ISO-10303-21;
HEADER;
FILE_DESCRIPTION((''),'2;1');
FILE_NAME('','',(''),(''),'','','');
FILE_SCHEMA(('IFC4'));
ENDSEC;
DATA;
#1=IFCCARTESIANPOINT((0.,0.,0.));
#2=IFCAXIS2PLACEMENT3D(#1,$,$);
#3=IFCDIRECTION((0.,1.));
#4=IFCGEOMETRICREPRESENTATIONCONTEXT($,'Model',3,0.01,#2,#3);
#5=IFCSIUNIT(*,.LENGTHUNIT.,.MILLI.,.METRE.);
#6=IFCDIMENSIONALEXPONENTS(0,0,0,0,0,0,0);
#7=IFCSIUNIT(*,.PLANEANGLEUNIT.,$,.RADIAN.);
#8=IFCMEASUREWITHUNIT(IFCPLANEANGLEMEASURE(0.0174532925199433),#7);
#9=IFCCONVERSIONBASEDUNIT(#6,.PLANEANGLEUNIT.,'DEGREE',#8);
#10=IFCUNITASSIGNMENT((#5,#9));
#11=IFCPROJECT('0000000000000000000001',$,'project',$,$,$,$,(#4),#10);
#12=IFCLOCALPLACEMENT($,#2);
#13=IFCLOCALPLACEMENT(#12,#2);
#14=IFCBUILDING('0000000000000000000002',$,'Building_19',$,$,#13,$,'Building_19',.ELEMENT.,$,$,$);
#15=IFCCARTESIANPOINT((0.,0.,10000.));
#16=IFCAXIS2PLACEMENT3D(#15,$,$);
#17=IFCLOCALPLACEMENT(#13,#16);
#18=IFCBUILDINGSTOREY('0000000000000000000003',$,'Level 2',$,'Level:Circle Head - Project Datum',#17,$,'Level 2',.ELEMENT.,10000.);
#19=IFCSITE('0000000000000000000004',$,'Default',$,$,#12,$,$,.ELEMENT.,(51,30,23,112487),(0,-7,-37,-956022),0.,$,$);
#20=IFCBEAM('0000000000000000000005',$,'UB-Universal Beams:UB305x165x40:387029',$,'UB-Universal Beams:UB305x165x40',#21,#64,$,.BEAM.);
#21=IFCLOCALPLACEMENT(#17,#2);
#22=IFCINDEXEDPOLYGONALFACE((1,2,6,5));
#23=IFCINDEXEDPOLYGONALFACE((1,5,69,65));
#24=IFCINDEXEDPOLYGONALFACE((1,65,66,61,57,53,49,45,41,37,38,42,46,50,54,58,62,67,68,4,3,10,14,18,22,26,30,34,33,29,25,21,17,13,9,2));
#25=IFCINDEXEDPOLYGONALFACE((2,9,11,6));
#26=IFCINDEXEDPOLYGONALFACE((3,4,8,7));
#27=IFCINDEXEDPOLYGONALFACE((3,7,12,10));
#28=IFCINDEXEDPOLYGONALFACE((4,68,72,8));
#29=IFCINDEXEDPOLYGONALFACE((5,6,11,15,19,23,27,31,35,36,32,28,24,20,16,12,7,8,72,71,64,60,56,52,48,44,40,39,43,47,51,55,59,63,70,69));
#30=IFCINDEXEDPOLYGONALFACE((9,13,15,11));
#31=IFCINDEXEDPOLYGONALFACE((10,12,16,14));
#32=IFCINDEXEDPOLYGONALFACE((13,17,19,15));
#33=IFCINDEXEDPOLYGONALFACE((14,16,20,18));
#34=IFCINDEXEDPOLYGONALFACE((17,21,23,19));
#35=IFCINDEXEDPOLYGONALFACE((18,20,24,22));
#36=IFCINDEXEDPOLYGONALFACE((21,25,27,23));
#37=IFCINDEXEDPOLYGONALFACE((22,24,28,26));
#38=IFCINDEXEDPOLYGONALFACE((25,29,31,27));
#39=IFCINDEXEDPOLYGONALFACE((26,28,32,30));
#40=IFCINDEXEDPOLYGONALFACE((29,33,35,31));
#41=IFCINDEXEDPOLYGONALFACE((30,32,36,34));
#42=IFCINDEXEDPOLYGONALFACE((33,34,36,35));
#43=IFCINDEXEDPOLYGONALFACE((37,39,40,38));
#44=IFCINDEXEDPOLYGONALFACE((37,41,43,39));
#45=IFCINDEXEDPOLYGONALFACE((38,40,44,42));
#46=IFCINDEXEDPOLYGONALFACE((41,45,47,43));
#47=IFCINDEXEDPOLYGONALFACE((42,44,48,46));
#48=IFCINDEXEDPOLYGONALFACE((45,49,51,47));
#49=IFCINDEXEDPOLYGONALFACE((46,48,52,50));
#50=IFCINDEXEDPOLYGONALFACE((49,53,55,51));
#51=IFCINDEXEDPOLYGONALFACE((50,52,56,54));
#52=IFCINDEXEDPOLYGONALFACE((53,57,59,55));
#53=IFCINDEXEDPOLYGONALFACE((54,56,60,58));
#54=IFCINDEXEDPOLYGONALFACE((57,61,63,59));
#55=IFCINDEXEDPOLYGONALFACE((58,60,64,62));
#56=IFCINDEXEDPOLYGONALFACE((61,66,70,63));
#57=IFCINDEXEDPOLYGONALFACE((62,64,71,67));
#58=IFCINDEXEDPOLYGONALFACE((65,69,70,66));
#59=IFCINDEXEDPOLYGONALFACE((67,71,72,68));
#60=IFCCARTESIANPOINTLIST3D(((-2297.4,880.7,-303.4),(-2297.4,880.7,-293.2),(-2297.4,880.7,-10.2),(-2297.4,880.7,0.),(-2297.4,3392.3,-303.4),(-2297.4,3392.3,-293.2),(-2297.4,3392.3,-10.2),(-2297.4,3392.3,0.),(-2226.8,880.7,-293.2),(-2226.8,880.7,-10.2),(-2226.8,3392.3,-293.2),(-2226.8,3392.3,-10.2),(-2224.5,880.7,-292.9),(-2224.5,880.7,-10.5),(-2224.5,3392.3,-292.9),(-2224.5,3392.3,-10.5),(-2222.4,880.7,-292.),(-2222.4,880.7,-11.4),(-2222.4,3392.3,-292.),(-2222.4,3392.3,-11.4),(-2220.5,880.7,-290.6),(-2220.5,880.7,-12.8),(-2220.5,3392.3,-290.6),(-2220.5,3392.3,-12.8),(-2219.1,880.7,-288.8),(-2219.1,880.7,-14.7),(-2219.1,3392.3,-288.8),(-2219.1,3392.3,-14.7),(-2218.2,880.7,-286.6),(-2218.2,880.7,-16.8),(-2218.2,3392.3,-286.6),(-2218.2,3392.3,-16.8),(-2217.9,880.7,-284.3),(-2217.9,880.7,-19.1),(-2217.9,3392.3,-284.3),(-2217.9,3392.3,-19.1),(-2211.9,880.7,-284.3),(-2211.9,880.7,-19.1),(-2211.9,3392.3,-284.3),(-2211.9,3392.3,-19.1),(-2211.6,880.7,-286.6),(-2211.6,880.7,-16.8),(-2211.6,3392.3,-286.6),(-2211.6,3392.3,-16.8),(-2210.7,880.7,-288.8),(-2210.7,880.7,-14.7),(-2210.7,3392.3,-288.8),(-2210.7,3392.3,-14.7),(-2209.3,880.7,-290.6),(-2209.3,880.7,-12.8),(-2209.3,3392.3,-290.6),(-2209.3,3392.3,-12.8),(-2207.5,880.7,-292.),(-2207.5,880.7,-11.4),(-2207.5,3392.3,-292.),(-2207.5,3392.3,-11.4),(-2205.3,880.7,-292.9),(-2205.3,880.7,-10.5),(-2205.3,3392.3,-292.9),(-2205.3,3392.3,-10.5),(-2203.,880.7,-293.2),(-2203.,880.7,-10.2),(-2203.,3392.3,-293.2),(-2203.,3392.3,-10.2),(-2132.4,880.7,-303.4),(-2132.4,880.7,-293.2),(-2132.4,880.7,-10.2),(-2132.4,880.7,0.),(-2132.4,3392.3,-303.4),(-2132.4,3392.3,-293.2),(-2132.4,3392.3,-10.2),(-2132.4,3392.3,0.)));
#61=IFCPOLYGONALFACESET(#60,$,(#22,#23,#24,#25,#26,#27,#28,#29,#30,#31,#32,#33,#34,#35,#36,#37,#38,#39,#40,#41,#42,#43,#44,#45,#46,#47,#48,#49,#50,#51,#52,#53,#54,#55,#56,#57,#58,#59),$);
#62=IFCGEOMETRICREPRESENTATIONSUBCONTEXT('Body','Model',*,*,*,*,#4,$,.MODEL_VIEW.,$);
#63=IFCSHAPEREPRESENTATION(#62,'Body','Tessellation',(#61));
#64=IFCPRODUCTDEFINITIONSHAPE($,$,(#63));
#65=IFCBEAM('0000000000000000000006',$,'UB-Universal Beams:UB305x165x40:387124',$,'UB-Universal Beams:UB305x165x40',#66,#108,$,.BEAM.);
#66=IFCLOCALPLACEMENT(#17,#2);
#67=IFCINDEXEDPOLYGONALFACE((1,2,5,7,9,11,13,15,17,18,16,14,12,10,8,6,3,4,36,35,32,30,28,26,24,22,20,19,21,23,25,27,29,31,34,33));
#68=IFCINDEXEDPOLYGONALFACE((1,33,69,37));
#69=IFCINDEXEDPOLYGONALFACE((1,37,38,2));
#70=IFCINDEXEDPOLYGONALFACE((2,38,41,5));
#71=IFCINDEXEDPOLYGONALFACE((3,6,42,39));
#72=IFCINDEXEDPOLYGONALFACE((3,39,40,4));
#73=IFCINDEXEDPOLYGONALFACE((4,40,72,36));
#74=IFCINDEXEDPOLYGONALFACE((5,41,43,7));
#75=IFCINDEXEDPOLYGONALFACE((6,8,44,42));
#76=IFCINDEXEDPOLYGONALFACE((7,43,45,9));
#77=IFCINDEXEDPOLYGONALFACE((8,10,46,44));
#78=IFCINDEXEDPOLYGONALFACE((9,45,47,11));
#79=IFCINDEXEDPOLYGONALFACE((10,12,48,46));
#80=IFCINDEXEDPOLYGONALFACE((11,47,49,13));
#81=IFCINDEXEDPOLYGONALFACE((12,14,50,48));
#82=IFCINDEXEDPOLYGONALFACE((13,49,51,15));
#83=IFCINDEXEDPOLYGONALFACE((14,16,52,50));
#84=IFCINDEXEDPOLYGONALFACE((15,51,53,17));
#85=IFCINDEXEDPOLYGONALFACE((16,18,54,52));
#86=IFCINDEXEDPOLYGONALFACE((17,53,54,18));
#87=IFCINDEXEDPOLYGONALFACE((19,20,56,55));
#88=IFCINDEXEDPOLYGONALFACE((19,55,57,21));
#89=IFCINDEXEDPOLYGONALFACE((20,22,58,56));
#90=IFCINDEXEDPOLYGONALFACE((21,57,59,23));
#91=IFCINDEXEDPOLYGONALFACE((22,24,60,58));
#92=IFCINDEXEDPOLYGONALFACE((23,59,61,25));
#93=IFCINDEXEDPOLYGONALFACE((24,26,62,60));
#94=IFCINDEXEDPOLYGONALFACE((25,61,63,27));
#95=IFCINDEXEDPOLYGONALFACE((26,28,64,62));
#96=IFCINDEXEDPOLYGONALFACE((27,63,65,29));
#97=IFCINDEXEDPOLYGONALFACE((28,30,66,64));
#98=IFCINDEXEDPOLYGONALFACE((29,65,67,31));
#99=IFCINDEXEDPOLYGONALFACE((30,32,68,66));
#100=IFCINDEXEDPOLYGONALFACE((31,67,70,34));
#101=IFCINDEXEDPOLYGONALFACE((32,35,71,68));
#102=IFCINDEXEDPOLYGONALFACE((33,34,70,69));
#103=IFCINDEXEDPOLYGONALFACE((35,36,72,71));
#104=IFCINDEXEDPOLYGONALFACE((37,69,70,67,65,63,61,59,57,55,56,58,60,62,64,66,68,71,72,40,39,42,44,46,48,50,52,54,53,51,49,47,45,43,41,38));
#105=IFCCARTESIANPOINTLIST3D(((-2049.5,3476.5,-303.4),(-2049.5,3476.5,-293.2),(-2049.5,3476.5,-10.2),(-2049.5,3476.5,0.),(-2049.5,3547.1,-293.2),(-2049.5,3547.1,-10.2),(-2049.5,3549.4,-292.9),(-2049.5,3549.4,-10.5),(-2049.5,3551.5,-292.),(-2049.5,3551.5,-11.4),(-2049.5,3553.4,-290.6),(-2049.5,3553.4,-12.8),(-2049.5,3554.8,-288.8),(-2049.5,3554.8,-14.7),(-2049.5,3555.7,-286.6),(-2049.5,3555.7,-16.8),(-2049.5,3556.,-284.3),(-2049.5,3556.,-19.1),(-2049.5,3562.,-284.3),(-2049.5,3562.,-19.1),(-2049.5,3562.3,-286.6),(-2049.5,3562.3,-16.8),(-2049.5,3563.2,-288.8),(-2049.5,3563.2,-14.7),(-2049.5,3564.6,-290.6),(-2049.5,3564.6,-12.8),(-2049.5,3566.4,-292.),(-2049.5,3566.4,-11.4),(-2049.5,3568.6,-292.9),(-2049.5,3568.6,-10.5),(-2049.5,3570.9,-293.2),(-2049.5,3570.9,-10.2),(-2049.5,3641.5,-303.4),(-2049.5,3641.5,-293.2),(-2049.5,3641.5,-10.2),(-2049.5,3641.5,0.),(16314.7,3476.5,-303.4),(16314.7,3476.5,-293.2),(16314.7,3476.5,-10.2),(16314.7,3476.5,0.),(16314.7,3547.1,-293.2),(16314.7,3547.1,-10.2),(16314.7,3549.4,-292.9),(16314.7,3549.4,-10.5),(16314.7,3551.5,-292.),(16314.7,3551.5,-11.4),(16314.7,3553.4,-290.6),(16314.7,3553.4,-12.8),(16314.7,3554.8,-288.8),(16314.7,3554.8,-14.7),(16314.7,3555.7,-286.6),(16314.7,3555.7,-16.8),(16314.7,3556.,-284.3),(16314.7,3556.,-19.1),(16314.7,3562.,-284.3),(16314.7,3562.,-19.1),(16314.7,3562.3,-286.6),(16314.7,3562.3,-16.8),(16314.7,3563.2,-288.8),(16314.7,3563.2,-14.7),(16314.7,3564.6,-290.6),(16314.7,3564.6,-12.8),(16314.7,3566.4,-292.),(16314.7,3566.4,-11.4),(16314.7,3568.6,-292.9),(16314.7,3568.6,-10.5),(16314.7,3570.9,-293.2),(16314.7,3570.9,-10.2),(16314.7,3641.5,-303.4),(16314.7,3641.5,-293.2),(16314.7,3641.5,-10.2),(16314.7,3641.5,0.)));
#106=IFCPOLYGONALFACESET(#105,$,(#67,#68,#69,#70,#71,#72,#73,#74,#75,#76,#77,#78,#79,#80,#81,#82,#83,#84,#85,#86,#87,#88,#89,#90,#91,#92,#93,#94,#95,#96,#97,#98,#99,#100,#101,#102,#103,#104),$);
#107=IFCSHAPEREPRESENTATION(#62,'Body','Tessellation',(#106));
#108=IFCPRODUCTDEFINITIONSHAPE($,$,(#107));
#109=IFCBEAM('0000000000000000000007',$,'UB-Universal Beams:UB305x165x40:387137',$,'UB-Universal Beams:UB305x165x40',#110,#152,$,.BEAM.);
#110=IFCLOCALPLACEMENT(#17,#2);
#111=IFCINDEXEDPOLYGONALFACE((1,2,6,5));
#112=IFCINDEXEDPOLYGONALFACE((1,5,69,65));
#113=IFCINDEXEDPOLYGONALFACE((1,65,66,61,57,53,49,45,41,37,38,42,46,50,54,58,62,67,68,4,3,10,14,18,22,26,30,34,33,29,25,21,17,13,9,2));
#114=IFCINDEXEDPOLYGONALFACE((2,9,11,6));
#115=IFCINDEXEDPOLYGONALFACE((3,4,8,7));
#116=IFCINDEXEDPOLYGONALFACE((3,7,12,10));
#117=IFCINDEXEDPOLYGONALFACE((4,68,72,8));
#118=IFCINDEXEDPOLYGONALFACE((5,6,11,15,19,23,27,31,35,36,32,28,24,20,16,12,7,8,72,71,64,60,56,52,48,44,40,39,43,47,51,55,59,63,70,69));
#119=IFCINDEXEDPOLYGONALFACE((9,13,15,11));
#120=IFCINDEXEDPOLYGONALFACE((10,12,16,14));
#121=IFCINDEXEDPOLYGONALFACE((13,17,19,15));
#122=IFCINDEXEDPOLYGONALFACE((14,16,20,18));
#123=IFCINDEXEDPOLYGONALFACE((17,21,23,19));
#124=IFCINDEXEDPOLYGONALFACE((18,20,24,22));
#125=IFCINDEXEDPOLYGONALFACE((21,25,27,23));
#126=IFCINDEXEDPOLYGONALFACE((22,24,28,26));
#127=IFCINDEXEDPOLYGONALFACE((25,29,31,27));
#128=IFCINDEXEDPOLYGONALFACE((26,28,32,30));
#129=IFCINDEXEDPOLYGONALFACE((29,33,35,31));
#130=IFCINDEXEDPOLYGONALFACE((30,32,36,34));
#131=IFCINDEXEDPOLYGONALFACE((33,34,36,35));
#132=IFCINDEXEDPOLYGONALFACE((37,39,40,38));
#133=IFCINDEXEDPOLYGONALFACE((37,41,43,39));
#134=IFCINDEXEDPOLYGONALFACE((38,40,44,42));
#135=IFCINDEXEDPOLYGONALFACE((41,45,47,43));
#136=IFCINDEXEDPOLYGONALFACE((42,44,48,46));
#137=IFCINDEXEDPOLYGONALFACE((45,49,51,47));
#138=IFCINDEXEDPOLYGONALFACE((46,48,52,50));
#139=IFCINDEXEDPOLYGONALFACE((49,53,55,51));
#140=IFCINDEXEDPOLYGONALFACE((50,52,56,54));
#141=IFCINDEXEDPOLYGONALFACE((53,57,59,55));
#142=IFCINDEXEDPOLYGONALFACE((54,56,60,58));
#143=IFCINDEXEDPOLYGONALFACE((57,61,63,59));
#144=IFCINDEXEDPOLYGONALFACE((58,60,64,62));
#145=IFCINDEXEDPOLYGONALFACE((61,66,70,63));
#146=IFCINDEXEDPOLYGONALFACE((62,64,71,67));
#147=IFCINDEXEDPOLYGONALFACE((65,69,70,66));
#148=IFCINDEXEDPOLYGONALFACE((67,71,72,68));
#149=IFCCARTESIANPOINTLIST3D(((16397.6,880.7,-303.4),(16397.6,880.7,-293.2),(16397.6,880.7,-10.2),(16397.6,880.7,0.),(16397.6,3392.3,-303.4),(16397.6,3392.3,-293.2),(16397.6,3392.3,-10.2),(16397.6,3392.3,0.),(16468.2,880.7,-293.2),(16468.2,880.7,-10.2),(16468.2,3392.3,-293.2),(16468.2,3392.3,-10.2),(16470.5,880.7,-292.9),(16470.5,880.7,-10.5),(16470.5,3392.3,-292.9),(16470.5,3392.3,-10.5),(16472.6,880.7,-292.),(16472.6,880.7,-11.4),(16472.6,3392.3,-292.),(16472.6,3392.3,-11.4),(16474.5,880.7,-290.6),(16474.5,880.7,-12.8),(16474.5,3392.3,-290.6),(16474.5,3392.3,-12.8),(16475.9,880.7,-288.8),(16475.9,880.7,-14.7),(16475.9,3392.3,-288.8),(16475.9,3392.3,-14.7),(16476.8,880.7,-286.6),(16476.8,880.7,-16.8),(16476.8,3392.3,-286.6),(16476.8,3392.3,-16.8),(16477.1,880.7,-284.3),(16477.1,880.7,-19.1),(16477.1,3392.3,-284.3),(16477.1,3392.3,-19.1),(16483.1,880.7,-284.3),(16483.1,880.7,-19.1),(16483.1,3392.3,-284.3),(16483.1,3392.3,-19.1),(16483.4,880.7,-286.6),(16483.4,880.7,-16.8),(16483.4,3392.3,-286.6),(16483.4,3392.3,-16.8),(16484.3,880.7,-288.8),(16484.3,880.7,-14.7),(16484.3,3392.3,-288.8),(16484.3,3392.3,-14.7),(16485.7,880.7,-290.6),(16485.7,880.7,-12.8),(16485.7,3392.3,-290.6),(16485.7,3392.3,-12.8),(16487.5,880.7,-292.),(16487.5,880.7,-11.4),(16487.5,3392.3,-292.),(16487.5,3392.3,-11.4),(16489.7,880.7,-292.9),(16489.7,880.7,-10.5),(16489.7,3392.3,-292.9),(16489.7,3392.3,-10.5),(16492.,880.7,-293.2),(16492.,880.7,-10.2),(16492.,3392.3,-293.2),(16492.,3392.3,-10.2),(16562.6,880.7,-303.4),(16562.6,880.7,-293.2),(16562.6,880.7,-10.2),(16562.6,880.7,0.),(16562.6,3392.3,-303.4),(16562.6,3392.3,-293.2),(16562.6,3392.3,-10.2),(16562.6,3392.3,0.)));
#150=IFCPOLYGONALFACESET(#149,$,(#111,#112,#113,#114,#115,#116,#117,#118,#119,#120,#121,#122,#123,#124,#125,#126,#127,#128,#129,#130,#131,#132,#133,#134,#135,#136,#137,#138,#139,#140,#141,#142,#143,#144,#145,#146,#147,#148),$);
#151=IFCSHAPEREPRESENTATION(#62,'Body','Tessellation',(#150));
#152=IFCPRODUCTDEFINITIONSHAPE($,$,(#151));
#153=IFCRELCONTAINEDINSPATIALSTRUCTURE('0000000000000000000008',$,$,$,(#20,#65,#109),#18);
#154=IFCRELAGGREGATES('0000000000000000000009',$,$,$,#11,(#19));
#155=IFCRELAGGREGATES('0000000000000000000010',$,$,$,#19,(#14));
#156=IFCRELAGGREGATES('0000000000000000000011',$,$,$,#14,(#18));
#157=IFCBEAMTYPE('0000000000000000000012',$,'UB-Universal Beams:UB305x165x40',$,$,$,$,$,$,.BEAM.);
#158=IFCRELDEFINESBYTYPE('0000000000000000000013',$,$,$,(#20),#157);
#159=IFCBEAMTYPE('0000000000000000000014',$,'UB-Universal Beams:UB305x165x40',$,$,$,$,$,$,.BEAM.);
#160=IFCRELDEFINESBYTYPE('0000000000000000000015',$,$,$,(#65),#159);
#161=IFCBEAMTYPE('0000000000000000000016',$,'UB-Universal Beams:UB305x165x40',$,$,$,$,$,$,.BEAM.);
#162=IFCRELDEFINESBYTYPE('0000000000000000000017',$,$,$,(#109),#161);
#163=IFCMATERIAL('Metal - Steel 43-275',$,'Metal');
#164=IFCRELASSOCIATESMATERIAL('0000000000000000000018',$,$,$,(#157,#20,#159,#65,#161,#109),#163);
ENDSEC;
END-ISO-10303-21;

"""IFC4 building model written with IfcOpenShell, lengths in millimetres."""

from ifc_helpers import new_model, entity, si_unit, converted_unit, direction, frame, origin, place, context, subcontext, project, spatial, line, arc, indexed_curve, outline, extrude, source, transform, mapped, material, type_object, type_shapes, element, save


model = new_model("IFC4")

# Units and contexts
model_context = context("Model", 3, precision=0.01, world=origin(), true_north=direction((0.0, 1.0)))
body_context = subcontext(model_context, "Body", "Model", "MODEL_VIEW")
ifc_project = project(units=[si_unit("LENGTHUNIT", "METRE", prefix="MILLI"), converted_unit("PLANEANGLEUNIT", "DEGREE", entity("IfcPlaneAngleMeasure", 0.0174532925199433), si_unit("PLANEANGLEUNIT", "RADIAN"), dimensions=[0, 0, 0, 0, 0, 0, 0])], contexts=[model_context])

# Site, building, storey
site_placement = place(None, origin())
site = spatial("IfcSite", under=ifc_project, at=site_placement, Name="Default", CompositionType="ELEMENT", RefLatitude=(51, 30, 23, 112487), RefLongitude=(0, -7, -37, -956022), RefElevation=0.0)
building_placement = place(site_placement, origin())
building = spatial("IfcBuilding", under=site, at=building_placement, Name="Building_19", LongName="Building_19", CompositionType="ELEMENT")
storey_placement = place(building_placement, frame((0.0, 0.0, 10000.0)))
storey = spatial("IfcBuildingStorey", under=building, at=storey_placement, Name="Level 2", ObjectType="Level:Circle Head - Project Datum", LongName="Level 2", CompositionType="ELEMENT", Elevation=10000.0)

# Beams
ifc_material_1 = material(Name="Metal - Steel 43-275", Category="Metal")
beam_type_1 = type_object("IfcBeamType", Name="UB-Universal Beams:UB305x165x40", PredefinedType="BEAM", material=ifc_material_1)
shared_shape_1 = source(origin(), body_context, "Body", "SweptSolid", [
    extrude(outline(indexed_curve([(-82.5, -141.5), (-82.5, -151.7), (82.5, -151.7), (82.5, -141.5), (11.9, -141.5), (5.6, -138.9), (3.0, -132.6), (3.0, 132.6), (5.6, 138.9), (11.9, 141.5), (82.5, 141.5), (82.5, 151.7), (-82.5, 151.7), (-82.5, 141.5), (-11.9, 141.5), (-5.6, 138.9), (-3.0, 132.6), (-3.0, -132.6), (-5.6, -138.9), (-11.9, -141.5)], segments=[line(1, 2, 3, 4, 5), arc(5, 6, 7), line(7, 8), arc(8, 9, 10), line(10, 11, 12, 13, 14, 15), arc(15, 16, 17), line(17, 18), arc(18, 19, 20), line(20, 1)], self_intersect=False)), frame((-1255.8, 0.0, 0.0), z_axis=(-1.0, 0.0, 0.0), x_axis=(0.0, -1.0, 0.0)), (0.0, 0.0, -1.0), 2511.6),
])
type_shapes(beam_type_1, [shared_shape_1])
beam_1_placement = place(storey_placement, frame((-2214.9, 2136.5, -151.7), z_axis=(0.0, 0.0, 1.0), x_axis=(0.0, 1.0, 0.0)))
element("IfcBeam", 1, at=beam_1_placement, inside=storey, type_object=beam_type_1, material=ifc_material_1, Name="UB-Universal Beams:UB305x165x40:387029", ObjectType="UB-Universal Beams:UB305x165x40", PredefinedType="BEAM", context=body_context, shape_type="MappedRepresentation", body=[
    mapped(shared_shape_1, transform((0.0, 0.0, 0.0), scale=1.0)),
])
beam_type_2 = type_object("IfcBeamType", Name="UB-Universal Beams:UB305x165x40", PredefinedType="BEAM", material=ifc_material_1)
shared_shape_2 = source(origin(), body_context, "Body", "SweptSolid", [
    extrude(outline(indexed_curve([(-82.5, -141.5), (-82.5, -151.7), (82.5, -151.7), (82.5, -141.5), (11.9, -141.5), (5.6, -138.9), (3.0, -132.6), (3.0, 132.6), (5.6, 138.9), (11.9, 141.5), (82.5, 141.5), (82.5, 151.7), (-82.5, 151.7), (-82.5, 141.5), (-11.9, 141.5), (-5.6, 138.9), (-3.0, 132.6), (-3.0, -132.6), (-5.6, -138.9), (-11.9, -141.5)], segments=[line(1, 2, 3, 4, 5), arc(5, 6, 7), line(7, 8), arc(8, 9, 10), line(10, 11, 12, 13, 14, 15), arc(15, 16, 17), line(17, 18), arc(18, 19, 20), line(20, 1)], self_intersect=False)), frame((-9182.1, 0.0, 0.0), z_axis=(-1.0, 0.0, 0.0), x_axis=(0.0, -1.0, 0.0)), (0.0, 0.0, -1.0), 18364.2),
])
type_shapes(beam_type_2, [shared_shape_2])
beam_2_placement = place(storey_placement, frame((7132.6, 3559.0, -151.7)))
element("IfcBeam", 2, at=beam_2_placement, inside=storey, type_object=beam_type_2, material=ifc_material_1, Name="UB-Universal Beams:UB305x165x40:387124", ObjectType="UB-Universal Beams:UB305x165x40", PredefinedType="BEAM", context=body_context, shape_type="MappedRepresentation", body=[
    mapped(shared_shape_2, transform((0.0, 0.0, 0.0), scale=1.0)),
])
beam_type_3 = type_object("IfcBeamType", Name="UB-Universal Beams:UB305x165x40", PredefinedType="BEAM", material=ifc_material_1)
shared_shape_3 = source(origin(), body_context, "Body", "SweptSolid", [
    extrude(outline(indexed_curve([(-82.5, -141.5), (-82.5, -151.7), (82.5, -151.7), (82.5, -141.5), (11.9, -141.5), (5.6, -138.9), (3.0, -132.6), (3.0, 132.6), (5.6, 138.9), (11.9, 141.5), (82.5, 141.5), (82.5, 151.7), (-82.5, 151.7), (-82.5, 141.5), (-11.9, 141.5), (-5.6, 138.9), (-3.0, 132.6), (-3.0, -132.6), (-5.6, -138.9), (-11.9, -141.5)], segments=[line(1, 2, 3, 4, 5), arc(5, 6, 7), line(7, 8), arc(8, 9, 10), line(10, 11, 12, 13, 14, 15), arc(15, 16, 17), line(17, 18), arc(18, 19, 20), line(20, 1)], self_intersect=False)), frame((-1233.3, 0.0, 0.0), z_axis=(-1.0, 0.0, 0.0), x_axis=(0.0, -1.0, 0.0)), (0.0, 0.0, -1.0), 2511.6),
])
type_shapes(beam_type_3, [shared_shape_3])
beam_3_placement = place(storey_placement, frame((16480.1, 2159.0, -151.7), z_axis=(0.0, 0.0, 1.0), x_axis=(0.0, -1.0, 0.0)))
element("IfcBeam", 3, at=beam_3_placement, inside=storey, type_object=beam_type_3, material=ifc_material_1, Name="UB-Universal Beams:UB305x165x40:387137", ObjectType="UB-Universal Beams:UB305x165x40", PredefinedType="BEAM", context=body_context, shape_type="MappedRepresentation", body=[
    mapped(shared_shape_3, transform((0.0, 0.0, 0.0), scale=1.0)),
])

save(model, "model.ifc")
